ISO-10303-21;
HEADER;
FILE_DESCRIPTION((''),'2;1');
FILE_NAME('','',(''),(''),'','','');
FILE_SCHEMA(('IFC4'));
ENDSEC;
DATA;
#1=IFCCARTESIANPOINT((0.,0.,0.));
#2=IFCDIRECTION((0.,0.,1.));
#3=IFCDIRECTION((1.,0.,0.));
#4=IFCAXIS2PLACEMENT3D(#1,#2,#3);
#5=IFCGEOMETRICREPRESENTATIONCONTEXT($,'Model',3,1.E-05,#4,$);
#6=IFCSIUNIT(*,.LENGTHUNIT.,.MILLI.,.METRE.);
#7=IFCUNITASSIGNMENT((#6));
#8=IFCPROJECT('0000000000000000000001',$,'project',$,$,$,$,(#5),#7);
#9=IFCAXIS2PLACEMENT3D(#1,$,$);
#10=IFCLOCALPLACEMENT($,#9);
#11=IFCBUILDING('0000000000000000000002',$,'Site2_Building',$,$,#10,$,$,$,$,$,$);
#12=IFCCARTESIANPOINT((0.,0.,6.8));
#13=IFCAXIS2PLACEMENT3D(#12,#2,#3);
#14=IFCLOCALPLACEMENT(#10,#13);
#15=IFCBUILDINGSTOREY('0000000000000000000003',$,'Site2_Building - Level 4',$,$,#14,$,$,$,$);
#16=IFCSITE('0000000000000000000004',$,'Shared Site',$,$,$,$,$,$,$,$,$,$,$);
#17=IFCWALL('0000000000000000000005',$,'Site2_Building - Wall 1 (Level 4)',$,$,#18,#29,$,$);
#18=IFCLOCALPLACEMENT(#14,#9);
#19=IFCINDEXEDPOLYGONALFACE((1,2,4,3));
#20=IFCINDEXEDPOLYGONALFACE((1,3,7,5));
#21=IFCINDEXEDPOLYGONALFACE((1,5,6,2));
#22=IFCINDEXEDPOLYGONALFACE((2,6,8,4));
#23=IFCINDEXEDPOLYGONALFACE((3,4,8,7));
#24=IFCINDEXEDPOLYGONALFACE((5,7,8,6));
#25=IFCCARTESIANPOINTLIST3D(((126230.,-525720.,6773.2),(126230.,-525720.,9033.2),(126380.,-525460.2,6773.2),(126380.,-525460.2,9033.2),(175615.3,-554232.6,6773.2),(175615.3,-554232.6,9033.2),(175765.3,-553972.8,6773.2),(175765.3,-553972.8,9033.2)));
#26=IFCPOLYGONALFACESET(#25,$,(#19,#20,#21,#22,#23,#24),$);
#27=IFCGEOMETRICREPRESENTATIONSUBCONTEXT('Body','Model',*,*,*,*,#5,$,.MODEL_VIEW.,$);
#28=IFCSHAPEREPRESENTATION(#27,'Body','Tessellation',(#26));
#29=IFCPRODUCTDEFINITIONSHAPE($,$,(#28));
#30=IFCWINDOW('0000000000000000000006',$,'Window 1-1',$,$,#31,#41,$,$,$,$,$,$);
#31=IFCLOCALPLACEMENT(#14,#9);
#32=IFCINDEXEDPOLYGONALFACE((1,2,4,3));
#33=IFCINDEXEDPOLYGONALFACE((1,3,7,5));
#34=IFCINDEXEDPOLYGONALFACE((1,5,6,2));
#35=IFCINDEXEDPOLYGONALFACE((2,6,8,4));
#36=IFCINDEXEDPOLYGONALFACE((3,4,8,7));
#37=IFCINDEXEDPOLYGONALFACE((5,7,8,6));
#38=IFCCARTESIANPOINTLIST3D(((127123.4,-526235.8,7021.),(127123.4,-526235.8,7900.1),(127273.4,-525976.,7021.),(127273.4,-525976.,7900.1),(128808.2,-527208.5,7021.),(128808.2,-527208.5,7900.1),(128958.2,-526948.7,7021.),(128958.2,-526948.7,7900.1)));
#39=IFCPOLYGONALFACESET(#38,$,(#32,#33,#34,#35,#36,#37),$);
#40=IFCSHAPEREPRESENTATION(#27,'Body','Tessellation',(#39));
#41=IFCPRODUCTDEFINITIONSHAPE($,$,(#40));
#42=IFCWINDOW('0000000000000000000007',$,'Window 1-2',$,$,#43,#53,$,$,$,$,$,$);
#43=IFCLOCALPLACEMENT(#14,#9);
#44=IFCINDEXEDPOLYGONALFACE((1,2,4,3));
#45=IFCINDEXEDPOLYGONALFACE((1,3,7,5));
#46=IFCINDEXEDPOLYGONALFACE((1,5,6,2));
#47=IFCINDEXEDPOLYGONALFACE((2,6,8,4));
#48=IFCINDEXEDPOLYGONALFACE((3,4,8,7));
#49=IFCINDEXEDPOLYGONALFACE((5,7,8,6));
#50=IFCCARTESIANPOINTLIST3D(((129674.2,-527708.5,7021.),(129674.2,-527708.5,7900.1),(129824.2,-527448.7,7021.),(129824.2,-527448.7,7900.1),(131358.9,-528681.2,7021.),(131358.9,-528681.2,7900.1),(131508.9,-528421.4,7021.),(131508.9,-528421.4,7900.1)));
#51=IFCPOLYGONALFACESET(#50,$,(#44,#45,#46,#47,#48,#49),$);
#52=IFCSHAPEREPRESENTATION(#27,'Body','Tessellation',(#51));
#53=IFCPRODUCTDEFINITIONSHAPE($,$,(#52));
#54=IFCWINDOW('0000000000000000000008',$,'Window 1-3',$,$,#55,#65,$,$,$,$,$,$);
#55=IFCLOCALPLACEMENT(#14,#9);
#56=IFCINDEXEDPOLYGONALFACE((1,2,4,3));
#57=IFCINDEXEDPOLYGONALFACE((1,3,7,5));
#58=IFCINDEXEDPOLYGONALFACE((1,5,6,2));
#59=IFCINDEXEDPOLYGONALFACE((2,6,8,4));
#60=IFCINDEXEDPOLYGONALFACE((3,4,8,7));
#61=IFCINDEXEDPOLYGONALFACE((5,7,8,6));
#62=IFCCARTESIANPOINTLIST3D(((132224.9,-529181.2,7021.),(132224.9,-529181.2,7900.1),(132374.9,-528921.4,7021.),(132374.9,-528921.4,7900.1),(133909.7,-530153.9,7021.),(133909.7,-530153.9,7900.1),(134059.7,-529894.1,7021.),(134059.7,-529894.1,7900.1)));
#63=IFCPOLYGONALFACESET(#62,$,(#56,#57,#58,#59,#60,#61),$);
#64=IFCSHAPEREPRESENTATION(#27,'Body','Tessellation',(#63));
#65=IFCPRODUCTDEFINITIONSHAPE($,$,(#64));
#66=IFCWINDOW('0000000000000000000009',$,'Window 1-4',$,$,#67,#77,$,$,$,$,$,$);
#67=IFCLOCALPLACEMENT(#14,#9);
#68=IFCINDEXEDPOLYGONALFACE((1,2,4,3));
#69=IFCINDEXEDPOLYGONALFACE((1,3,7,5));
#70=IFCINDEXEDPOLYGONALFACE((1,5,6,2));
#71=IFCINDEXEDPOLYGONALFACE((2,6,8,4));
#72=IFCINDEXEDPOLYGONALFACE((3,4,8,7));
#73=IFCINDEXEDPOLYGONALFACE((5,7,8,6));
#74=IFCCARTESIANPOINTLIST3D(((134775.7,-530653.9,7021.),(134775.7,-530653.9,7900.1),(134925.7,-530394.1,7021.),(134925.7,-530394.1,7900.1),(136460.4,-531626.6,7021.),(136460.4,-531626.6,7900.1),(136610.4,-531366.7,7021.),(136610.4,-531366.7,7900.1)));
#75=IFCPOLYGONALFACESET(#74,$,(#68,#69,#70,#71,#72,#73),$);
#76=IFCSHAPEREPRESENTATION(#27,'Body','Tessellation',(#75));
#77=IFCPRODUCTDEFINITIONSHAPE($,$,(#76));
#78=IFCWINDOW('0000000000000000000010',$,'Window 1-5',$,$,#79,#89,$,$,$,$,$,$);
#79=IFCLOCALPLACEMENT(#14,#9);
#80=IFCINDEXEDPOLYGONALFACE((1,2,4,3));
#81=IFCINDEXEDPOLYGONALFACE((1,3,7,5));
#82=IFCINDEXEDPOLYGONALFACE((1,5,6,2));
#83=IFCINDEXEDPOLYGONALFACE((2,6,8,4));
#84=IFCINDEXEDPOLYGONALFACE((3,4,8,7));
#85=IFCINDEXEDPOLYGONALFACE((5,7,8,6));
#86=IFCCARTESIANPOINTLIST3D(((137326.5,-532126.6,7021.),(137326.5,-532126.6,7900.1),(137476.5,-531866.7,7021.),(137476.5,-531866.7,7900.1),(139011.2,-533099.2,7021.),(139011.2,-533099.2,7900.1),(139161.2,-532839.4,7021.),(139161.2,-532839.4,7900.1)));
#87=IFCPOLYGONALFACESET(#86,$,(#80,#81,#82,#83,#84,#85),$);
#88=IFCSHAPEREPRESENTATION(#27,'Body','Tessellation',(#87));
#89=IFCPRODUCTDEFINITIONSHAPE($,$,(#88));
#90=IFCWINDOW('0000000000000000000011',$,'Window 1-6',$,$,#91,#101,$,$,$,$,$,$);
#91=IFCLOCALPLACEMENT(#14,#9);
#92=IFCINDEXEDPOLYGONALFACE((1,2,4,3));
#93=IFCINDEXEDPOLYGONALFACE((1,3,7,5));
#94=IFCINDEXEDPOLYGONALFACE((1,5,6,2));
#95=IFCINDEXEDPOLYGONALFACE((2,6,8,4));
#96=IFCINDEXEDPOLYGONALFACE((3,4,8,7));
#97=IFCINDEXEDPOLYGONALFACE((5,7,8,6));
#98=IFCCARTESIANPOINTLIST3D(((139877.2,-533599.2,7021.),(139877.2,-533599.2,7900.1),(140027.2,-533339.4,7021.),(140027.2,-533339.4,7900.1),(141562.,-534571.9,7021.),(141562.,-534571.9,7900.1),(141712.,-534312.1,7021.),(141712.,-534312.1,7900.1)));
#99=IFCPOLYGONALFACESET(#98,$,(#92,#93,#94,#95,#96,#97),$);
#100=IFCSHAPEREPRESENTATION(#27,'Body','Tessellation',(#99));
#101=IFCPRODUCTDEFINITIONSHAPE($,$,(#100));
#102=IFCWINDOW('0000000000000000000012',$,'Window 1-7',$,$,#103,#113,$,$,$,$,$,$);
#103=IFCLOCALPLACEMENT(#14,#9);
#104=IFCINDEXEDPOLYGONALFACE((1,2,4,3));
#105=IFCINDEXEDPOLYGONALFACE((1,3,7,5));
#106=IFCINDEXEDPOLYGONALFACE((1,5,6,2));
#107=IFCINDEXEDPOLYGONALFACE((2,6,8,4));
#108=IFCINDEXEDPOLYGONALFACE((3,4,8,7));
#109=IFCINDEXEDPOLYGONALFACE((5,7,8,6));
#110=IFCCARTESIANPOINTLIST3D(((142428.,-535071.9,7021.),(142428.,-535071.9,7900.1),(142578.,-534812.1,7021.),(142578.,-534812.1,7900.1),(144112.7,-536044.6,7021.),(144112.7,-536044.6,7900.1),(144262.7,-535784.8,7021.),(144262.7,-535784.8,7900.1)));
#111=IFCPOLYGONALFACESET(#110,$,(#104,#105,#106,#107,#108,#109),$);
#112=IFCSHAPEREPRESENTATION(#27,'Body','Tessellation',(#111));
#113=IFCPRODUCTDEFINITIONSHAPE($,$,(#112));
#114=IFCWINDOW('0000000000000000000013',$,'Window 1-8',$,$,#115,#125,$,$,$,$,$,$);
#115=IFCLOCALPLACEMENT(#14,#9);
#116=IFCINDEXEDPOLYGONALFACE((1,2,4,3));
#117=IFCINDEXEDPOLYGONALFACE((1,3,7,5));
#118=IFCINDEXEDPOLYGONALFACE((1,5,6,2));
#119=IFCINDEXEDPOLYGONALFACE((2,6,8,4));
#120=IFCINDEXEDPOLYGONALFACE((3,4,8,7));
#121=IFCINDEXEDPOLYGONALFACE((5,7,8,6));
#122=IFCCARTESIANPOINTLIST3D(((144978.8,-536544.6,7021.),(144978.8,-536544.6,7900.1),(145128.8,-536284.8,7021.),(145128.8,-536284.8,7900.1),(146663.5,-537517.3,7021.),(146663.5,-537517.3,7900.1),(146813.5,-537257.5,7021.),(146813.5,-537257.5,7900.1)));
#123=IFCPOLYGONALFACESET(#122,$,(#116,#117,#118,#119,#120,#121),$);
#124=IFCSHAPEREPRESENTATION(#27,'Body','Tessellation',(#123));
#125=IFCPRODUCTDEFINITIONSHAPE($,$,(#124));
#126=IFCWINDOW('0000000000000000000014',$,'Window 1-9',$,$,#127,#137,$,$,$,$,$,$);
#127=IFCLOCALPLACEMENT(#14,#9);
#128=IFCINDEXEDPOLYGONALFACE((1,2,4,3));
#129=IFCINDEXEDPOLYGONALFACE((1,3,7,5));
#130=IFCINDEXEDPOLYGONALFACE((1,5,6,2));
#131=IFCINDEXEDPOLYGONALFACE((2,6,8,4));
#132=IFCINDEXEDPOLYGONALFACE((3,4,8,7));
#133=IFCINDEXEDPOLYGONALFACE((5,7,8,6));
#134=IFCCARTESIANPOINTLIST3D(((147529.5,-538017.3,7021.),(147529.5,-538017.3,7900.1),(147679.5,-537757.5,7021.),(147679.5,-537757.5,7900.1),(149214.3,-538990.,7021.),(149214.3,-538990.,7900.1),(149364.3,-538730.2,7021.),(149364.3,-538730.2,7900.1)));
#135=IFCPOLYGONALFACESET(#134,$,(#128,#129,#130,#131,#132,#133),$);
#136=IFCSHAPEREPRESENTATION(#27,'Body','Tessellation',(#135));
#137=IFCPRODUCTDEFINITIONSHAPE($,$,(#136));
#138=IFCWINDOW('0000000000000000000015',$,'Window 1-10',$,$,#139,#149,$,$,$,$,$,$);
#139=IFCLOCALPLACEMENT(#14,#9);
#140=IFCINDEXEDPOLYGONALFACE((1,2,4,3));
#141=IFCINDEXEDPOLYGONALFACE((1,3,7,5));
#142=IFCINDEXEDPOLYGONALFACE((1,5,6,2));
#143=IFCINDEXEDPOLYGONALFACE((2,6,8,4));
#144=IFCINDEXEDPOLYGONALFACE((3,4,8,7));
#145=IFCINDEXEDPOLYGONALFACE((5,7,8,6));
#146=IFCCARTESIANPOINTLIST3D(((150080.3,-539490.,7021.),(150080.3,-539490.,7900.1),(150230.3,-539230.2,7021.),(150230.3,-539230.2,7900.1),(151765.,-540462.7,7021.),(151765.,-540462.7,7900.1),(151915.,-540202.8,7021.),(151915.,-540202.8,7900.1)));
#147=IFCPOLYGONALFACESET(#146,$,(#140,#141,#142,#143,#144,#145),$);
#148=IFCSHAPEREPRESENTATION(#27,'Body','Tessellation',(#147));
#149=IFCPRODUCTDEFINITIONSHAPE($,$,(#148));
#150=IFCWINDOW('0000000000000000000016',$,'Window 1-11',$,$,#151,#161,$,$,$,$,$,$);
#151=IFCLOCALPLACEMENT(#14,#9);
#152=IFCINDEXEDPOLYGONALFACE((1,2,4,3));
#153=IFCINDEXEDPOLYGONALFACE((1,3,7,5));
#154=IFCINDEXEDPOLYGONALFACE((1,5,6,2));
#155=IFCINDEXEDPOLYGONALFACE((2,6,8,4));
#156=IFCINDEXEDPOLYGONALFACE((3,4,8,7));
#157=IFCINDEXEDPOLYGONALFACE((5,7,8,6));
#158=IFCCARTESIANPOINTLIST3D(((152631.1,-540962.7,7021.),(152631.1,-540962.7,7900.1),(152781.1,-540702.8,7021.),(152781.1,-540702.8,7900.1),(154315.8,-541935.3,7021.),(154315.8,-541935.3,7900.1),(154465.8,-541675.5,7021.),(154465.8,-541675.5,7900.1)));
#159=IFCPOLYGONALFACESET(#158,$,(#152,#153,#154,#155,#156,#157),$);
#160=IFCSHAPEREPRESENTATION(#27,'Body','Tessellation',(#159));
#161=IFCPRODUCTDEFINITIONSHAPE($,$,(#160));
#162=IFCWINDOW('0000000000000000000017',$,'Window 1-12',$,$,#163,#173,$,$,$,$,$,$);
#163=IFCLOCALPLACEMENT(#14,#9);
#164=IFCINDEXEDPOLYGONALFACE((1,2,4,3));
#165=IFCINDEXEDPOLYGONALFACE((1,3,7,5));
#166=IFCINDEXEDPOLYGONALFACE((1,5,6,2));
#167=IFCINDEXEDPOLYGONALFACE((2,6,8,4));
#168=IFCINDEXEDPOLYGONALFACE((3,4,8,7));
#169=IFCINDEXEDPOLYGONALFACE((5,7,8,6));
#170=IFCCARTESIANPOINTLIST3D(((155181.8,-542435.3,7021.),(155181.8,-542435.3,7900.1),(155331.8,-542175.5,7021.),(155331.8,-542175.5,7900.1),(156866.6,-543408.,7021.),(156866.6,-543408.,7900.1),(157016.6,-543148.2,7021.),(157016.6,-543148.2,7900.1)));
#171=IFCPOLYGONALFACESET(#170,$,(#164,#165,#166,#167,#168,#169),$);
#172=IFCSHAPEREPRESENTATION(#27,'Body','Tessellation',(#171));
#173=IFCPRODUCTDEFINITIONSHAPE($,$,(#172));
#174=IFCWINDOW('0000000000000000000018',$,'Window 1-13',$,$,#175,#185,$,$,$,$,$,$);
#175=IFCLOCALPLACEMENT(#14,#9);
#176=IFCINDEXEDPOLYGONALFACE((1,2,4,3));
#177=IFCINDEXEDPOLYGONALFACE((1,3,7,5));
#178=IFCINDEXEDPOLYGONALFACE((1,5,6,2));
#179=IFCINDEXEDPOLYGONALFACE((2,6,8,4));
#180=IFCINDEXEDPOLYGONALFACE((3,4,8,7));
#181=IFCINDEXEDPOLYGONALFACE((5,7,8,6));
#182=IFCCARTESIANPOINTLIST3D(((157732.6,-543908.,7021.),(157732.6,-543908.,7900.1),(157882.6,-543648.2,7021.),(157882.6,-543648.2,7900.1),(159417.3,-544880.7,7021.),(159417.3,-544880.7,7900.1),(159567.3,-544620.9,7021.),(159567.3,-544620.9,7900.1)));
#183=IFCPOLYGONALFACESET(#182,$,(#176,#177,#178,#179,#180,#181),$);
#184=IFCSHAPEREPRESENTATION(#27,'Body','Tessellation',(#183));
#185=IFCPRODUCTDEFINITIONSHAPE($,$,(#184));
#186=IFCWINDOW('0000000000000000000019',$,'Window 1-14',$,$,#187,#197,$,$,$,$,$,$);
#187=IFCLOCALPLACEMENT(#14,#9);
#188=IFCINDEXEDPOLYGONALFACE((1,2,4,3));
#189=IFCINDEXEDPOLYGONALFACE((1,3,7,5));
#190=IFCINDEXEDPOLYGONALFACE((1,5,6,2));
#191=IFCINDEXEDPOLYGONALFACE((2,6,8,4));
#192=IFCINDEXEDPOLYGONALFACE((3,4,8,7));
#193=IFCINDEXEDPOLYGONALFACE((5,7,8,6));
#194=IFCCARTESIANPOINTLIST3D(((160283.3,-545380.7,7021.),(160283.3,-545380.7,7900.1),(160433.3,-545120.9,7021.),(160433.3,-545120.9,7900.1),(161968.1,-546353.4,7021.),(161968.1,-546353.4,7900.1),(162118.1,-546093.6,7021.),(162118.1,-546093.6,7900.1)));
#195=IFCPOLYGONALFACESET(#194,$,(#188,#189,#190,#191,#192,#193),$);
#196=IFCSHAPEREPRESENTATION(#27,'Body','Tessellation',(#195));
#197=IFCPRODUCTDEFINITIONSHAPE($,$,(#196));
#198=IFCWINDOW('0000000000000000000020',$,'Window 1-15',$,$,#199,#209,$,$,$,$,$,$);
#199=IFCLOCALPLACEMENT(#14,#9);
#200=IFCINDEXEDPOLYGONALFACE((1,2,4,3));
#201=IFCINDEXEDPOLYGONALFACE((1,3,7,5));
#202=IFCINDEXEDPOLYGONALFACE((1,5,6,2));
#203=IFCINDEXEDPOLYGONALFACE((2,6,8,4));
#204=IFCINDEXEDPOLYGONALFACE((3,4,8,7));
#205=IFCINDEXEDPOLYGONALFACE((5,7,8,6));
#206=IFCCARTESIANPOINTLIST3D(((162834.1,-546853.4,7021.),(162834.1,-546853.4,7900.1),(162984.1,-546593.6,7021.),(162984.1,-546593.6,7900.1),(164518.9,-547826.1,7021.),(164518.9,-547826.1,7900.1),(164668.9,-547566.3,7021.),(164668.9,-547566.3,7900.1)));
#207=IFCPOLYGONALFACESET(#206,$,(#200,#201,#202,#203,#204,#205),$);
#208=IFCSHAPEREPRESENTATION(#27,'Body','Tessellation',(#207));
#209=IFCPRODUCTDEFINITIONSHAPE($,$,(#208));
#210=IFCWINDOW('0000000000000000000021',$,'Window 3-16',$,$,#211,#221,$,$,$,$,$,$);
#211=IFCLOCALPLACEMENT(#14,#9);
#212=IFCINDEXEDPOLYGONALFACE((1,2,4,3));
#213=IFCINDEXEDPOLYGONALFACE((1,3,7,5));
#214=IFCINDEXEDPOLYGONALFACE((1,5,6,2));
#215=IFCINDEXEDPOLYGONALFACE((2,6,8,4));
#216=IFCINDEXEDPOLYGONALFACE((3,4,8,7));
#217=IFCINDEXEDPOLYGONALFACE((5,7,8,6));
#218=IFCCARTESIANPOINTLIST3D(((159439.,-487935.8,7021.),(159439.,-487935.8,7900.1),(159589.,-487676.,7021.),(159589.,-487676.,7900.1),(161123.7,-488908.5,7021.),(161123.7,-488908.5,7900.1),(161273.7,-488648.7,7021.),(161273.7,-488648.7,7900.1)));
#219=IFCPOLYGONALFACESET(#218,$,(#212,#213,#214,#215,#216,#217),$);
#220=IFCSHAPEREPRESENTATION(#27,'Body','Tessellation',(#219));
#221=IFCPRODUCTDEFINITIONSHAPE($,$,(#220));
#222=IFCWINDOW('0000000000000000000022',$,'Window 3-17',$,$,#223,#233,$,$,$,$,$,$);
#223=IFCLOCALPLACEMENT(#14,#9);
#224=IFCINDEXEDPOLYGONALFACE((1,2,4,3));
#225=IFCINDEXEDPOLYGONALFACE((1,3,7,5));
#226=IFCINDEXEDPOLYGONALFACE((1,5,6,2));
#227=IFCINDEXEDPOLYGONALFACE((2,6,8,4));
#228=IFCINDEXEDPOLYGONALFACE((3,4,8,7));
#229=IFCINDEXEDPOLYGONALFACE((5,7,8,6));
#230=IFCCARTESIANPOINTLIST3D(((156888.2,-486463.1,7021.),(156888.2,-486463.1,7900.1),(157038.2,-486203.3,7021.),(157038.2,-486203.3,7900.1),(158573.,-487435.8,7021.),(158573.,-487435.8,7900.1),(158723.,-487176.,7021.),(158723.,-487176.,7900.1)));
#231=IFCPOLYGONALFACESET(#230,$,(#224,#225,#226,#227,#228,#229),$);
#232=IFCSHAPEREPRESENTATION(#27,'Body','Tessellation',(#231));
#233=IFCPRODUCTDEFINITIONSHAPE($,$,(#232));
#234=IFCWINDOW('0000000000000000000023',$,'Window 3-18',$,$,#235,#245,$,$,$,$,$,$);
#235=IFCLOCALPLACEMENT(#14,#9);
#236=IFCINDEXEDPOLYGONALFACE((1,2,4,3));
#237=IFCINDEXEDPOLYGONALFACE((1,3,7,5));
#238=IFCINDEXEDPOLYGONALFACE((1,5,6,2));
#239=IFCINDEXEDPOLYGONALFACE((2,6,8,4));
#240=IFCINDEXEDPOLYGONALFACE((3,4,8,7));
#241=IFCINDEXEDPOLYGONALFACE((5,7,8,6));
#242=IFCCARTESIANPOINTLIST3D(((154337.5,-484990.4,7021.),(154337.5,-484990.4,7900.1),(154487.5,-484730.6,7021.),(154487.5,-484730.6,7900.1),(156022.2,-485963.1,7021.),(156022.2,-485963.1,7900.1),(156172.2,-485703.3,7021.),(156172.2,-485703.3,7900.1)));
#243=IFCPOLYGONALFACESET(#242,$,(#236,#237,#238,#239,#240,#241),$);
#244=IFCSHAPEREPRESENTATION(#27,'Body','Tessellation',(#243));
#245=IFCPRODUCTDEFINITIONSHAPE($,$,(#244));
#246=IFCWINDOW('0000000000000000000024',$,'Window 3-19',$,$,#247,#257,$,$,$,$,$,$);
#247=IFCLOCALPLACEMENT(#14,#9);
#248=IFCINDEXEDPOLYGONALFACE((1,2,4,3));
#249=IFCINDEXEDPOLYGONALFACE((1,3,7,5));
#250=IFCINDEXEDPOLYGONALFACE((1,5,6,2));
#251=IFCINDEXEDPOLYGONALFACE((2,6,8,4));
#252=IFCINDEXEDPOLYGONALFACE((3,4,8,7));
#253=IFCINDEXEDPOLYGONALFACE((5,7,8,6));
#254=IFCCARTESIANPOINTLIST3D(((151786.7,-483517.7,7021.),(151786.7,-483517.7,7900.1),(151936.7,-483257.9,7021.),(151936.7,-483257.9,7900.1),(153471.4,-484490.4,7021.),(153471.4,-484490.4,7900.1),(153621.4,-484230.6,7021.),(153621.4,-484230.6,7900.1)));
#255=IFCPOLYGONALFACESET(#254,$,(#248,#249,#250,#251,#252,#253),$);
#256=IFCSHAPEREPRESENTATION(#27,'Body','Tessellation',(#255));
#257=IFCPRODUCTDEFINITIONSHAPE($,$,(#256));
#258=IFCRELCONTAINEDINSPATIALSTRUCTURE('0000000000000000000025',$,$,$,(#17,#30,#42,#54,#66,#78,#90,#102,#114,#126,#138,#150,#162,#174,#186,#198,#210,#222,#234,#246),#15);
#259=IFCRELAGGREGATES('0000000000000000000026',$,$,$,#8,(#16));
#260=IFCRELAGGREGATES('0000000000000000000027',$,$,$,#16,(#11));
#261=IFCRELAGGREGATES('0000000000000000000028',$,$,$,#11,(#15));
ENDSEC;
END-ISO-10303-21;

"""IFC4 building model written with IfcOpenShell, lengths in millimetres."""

from ifc_helpers import new_model, si_unit, frame, origin, origin_with_axes, place, context, subcontext, project, spatial, indexed_curve, outline, extrude, element, save


model = new_model("IFC4")

# Units and contexts
model_context = context("Model", 3, precision=1e-05, world=origin_with_axes())
body_context = subcontext(model_context, "Body", "Model", "MODEL_VIEW")
ifc_project = project(units=[si_unit("LENGTHUNIT", "METRE", prefix="MILLI")], contexts=[model_context])

# Site, building, storey
site = spatial("IfcSite", under=ifc_project, Name="Shared Site")
building_placement = place(None, origin())
building = spatial("IfcBuilding", under=site, at=building_placement, Name="Site2_Building")
storey_placement = place(building_placement, frame((0.0, 0.0, 6.8), z_axis=(0.0, 0.0, 1.0), x_axis=(1.0, 0.0, 0.0)))
storey = spatial("IfcBuildingStorey", under=building, at=storey_placement, Name="Site2_Building - Level 4")

# Wall
wall_1_placement = place(storey_placement, frame((126230.0, -525720.0, 6773.2), z_axis=(0.0, 0.0, 1.0), x_axis=(0.866025, -0.5, 0.0)))
element("IfcWall", 1, at=wall_1_placement, inside=storey, Name="Site2_Building - Wall 1 (Level 4)", context=body_context, shape_type="SweptSolid", body=[
    extrude(outline(indexed_curve([(0.0, 0.0), (0.0, 300.0), (57025.3, 300.0), (57025.3, 0.0), (0.0, 0.0)], self_intersect=False)), origin_with_axes(), (0.0, 0.0, 1.0), 2260.0),
])

# Windows
for number, where, z_axis, x_axis, name in (
    (2, (127123.4, -526235.8, 7021.0), (0.0, 0.0, 1.0), (0.866025, -0.5, 0.0), "Window 1-1"),
    (3, (129674.2, -527708.5, 7021.0), (0.0, 0.0, 1.0), (0.866025, -0.5, 0.0), "Window 1-2"),
    (4, (132224.9, -529181.2, 7021.0), (0.0, 0.0, 1.0), (0.866025, -0.5, 0.0), "Window 1-3"),
    (5, (134775.7, -530653.9, 7021.0), (0.0, 0.0, 1.0), (0.866025, -0.5, 0.0), "Window 1-4"),
    (6, (137326.5, -532126.6, 7021.0), (0.0, 0.0, 1.0), (0.866025, -0.5, 0.0), "Window 1-5"),
    (7, (139877.2, -533599.2, 7021.0), (0.0, 0.0, 1.0), (0.866025, -0.5, 0.0), "Window 1-6"),
    (8, (142428.0, -535071.9, 7021.0), (0.0, 0.0, 1.0), (0.866025, -0.5, 0.0), "Window 1-7"),
    (9, (144978.8, -536544.6, 7021.0), (0.0, 0.0, 1.0), (0.866025, -0.5, 0.0), "Window 1-8"),
    (10, (147529.5, -538017.3, 7021.0), (0.0, 0.0, 1.0), (0.866025, -0.5, 0.0), "Window 1-9"),
    (11, (150080.3, -539490.0, 7021.0), (0.0, 0.0, 1.0), (0.866025, -0.5, 0.0), "Window 1-10"),
    (12, (152631.1, -540962.7, 7021.0), (0.0, 0.0, 1.0), (0.866025, -0.5, 0.0), "Window 1-11"),
    (13, (155181.8, -542435.3, 7021.0), (0.0, 0.0, 1.0), (0.866025, -0.5, 0.0), "Window 1-12"),
    (14, (157732.6, -543908.0, 7021.0), (0.0, 0.0, 1.0), (0.866025, -0.5, 0.0), "Window 1-13"),
    (15, (160283.3, -545380.7, 7021.0), (0.0, 0.0, 1.0), (0.866025, -0.5, 0.0), "Window 1-14"),
    (16, (162834.1, -546853.4, 7021.0), (0.0, 0.0, 1.0), (0.866025, -0.5, 0.0), "Window 1-15"),
    (17, (161273.7, -488648.7, 7021.0), (0.0, 0.0, 1.0), (-0.866025, 0.5, 0.0), "Window 3-16"),
    (18, (158723.0, -487176.0, 7021.0), (0.0, 0.0, 1.0), (-0.866025, 0.5, 0.0), "Window 3-17"),
    (19, (156172.2, -485703.3, 7021.0), (0.0, 0.0, 1.0), (-0.866025, 0.5, 0.0), "Window 3-18"),
    (20, (153621.4, -484230.6, 7021.0), (0.0, 0.0, 1.0), (-0.866025, 0.5, 0.0), "Window 3-19"),
):
    element("IfcWindow", number, at=place(storey_placement, frame(where, z_axis=z_axis, x_axis=x_axis)), inside=storey, Name=name, context=body_context, shape_type="SweptSolid", body=[
        extrude(outline(indexed_curve([(0.0, 0.0), (0.0, 300.0), (1945.4, 300.0), (1945.4, 0.0), (0.0, 0.0)], self_intersect=False)), origin_with_axes(), (0.0, 0.0, 1.0), 879.1),
    ])

save(model, "model.ifc")
